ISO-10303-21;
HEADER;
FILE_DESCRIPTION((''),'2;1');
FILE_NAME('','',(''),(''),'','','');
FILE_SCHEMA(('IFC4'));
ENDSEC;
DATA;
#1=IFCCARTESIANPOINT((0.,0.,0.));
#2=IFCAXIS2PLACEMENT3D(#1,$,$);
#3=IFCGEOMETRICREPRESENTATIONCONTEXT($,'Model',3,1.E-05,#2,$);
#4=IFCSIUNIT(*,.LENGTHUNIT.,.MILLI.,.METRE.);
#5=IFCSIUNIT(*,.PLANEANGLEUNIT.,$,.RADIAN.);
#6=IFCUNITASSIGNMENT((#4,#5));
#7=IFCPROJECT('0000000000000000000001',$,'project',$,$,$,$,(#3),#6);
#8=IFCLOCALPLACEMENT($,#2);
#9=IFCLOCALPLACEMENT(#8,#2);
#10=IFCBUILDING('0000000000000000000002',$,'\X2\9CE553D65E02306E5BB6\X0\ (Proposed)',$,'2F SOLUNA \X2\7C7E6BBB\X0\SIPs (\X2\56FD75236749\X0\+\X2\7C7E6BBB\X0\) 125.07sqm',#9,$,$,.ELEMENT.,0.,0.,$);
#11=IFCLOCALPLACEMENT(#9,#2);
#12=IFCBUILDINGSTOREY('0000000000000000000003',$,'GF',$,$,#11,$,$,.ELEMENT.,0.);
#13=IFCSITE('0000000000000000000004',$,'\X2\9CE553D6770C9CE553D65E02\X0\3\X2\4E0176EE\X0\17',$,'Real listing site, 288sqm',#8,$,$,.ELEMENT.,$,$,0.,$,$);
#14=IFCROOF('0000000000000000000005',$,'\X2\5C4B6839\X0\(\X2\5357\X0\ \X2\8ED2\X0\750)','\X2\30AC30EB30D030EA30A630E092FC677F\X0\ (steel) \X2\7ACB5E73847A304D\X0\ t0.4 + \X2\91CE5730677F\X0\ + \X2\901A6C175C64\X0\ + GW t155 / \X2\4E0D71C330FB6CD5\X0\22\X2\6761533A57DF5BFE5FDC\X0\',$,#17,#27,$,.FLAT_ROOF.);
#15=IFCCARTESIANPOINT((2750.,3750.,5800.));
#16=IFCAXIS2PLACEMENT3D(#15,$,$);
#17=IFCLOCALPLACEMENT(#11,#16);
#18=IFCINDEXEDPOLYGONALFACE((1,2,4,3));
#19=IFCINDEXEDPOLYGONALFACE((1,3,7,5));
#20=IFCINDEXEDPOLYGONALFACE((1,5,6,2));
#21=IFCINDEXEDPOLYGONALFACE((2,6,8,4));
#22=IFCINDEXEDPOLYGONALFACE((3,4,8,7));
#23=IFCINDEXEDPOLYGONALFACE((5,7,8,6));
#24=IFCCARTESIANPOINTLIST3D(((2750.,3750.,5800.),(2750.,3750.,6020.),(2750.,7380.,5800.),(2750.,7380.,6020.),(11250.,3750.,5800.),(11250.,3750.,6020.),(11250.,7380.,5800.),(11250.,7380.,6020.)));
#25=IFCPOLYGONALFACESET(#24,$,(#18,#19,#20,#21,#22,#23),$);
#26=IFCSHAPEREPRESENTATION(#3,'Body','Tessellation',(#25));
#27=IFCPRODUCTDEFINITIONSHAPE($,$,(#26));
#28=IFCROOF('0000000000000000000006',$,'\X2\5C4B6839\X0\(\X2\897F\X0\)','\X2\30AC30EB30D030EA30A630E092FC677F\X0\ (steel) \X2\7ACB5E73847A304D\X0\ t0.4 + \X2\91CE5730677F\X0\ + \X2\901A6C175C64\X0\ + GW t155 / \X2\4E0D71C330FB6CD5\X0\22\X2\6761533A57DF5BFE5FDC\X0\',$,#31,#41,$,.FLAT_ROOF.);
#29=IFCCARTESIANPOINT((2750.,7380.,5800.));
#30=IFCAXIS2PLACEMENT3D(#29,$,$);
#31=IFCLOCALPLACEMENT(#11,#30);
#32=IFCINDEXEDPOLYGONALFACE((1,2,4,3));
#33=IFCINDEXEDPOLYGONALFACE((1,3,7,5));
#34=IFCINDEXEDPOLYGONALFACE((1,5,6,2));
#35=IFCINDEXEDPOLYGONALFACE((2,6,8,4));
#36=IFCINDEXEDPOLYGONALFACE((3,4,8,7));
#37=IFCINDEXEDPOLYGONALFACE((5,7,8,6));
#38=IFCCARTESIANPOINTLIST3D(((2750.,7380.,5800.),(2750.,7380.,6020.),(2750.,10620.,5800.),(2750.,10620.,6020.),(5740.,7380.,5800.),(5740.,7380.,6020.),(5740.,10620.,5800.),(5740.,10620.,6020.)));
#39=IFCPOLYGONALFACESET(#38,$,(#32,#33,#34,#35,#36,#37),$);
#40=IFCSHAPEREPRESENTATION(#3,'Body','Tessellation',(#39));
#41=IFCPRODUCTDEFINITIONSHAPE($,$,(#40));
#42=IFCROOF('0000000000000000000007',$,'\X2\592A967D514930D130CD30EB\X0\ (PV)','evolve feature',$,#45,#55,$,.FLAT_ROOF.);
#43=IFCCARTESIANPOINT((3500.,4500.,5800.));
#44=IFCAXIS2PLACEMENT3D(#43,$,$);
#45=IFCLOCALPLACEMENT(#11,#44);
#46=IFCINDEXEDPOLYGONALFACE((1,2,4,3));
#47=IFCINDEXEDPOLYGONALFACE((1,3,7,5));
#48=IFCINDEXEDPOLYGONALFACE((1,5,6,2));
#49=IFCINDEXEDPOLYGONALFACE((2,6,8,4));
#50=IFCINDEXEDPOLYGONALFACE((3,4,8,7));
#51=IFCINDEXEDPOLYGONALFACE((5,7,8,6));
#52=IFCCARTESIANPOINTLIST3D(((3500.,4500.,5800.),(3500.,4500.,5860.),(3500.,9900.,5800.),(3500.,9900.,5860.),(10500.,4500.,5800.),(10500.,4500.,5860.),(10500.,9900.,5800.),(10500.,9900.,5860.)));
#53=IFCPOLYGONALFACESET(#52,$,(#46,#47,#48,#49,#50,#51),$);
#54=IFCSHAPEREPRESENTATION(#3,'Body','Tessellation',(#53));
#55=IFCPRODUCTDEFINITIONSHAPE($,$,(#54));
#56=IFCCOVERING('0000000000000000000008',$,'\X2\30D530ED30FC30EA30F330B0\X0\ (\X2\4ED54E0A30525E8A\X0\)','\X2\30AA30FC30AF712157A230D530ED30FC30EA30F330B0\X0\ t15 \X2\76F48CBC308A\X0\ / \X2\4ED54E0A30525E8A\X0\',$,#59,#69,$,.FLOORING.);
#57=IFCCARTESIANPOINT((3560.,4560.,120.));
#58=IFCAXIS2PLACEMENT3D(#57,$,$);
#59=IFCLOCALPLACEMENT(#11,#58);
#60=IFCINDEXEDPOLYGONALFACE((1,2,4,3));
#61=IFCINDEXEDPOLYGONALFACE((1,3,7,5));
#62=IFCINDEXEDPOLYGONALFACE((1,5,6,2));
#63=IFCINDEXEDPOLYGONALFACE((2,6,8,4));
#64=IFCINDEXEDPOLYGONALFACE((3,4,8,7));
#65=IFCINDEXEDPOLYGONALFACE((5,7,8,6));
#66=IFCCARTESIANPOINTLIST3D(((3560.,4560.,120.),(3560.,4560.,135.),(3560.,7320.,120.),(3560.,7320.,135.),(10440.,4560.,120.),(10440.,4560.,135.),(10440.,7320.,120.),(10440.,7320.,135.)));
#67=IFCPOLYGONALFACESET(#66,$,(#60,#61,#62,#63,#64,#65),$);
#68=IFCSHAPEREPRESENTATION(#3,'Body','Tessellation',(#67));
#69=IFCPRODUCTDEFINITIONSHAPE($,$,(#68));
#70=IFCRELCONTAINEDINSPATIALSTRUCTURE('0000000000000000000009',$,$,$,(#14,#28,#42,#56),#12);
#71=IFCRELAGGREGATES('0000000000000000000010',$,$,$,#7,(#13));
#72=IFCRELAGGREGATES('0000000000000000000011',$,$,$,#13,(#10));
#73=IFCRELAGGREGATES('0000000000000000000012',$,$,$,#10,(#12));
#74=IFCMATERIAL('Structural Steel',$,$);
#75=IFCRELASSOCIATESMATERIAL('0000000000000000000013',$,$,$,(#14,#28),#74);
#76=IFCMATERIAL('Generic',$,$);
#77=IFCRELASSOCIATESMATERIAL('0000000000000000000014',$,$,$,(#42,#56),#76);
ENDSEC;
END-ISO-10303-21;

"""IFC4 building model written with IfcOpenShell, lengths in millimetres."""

from ifc_helpers import new_model, si_unit, frame, frame_2d, origin, place, context, project, spatial, rectangle, extrude, material, element, save


model = new_model("IFC4")

# Units and contexts
model_context = context("Model", 3, precision=1e-05, world=origin())
ifc_project = project(units=[si_unit("LENGTHUNIT", "METRE", prefix="MILLI"), si_unit("PLANEANGLEUNIT", "RADIAN")], contexts=[model_context])

# Site, building, storey
site_placement = place(None, origin())
site = spatial("IfcSite", under=ifc_project, at=site_placement, Name="鳥取県鳥取市3丁目17", ObjectType="Real listing site, 288sqm", CompositionType="ELEMENT", RefElevation=0.0)
building_placement = place(site_placement, origin())
building = spatial("IfcBuilding", under=site, at=building_placement, Name="鳥取市の家 (Proposed)", ObjectType="2F SOLUNA 籾殻SIPs (国産杉+籾殻) 125.07sqm", CompositionType="ELEMENT", ElevationOfRefHeight=0.0, ElevationOfTerrain=0.0)
storey_placement = place(building_placement, origin())
storey = spatial("IfcBuildingStorey", under=building, at=storey_placement, Name="GF", CompositionType="ELEMENT", Elevation=0.0)

# Shared definitions
ifc_material_1 = material(Name="Generic")

# Roofs
ifc_material_2 = material(Name="Structural Steel")
roof_1_placement = place(storey_placement, frame((2750.0, 3750.0, 5800.0)))
element("IfcRoof", 1, at=roof_1_placement, inside=storey, material=ifc_material_2, Name="屋根(南 軒750)", Description="ガルバリウム鋼板 (steel) 立平葺き t0.4 + 野地板 + 通気層 + GW t155 / 不燃・法22条区域対応", PredefinedType="FLAT_ROOF", context=model_context, shape_type="SweptSolid", body=[
    extrude(rectangle(XDim=8500.0, YDim=3630.0, at=frame_2d((4250.0, 1815.0))), frame((2750.0, 3750.0, 5800.0)), (0.0, 0.0, 1.0), 220.0),
])
roof_2_placement = place(storey_placement, frame((2750.0, 7380.0, 5800.0)))
element("IfcRoof", 2, at=roof_2_placement, inside=storey, material=ifc_material_2, Name="屋根(西)", Description="ガルバリウム鋼板 (steel) 立平葺き t0.4 + 野地板 + 通気層 + GW t155 / 不燃・法22条区域対応", PredefinedType="FLAT_ROOF", context=model_context, shape_type="SweptSolid", body=[
    extrude(rectangle(XDim=2990.0, YDim=3240.0, at=frame_2d((1495.0, 1620.0))), frame((2750.0, 7380.0, 5800.0)), (0.0, 0.0, 1.0), 220.0),
])
roof_3_placement = place(storey_placement, frame((3500.0, 4500.0, 5800.0)))
element("IfcRoof", 3, at=roof_3_placement, inside=storey, material=ifc_material_1, Name="太陽光パネル (PV)", Description="evolve feature", PredefinedType="FLAT_ROOF", context=model_context, shape_type="SweptSolid", body=[
    extrude(rectangle(XDim=7000.0, YDim=5400.0, at=frame_2d((3500.0, 2700.0))), frame((3500.0, 4500.0, 5800.0)), (0.0, 0.0, 1.0), 60.0),
])

# Covering
covering_placement = place(storey_placement, frame((3560.0, 4560.0, 120.0)))
element("IfcCovering", 4, at=covering_placement, inside=storey, material=ifc_material_1, Name="フローリング (仕上げ床)", Description="オーク無垢フローリング t15 直貼り / 仕上げ床", PredefinedType="FLOORING", context=model_context, shape_type="SweptSolid", body=[
    extrude(rectangle(XDim=6880.0, YDim=2760.0, at=frame_2d((3440.0, 1380.0))), frame((3560.0, 4560.0, 120.0)), (0.0, 0.0, 1.0), 15.0),
])

save(model, "model.ifc")
